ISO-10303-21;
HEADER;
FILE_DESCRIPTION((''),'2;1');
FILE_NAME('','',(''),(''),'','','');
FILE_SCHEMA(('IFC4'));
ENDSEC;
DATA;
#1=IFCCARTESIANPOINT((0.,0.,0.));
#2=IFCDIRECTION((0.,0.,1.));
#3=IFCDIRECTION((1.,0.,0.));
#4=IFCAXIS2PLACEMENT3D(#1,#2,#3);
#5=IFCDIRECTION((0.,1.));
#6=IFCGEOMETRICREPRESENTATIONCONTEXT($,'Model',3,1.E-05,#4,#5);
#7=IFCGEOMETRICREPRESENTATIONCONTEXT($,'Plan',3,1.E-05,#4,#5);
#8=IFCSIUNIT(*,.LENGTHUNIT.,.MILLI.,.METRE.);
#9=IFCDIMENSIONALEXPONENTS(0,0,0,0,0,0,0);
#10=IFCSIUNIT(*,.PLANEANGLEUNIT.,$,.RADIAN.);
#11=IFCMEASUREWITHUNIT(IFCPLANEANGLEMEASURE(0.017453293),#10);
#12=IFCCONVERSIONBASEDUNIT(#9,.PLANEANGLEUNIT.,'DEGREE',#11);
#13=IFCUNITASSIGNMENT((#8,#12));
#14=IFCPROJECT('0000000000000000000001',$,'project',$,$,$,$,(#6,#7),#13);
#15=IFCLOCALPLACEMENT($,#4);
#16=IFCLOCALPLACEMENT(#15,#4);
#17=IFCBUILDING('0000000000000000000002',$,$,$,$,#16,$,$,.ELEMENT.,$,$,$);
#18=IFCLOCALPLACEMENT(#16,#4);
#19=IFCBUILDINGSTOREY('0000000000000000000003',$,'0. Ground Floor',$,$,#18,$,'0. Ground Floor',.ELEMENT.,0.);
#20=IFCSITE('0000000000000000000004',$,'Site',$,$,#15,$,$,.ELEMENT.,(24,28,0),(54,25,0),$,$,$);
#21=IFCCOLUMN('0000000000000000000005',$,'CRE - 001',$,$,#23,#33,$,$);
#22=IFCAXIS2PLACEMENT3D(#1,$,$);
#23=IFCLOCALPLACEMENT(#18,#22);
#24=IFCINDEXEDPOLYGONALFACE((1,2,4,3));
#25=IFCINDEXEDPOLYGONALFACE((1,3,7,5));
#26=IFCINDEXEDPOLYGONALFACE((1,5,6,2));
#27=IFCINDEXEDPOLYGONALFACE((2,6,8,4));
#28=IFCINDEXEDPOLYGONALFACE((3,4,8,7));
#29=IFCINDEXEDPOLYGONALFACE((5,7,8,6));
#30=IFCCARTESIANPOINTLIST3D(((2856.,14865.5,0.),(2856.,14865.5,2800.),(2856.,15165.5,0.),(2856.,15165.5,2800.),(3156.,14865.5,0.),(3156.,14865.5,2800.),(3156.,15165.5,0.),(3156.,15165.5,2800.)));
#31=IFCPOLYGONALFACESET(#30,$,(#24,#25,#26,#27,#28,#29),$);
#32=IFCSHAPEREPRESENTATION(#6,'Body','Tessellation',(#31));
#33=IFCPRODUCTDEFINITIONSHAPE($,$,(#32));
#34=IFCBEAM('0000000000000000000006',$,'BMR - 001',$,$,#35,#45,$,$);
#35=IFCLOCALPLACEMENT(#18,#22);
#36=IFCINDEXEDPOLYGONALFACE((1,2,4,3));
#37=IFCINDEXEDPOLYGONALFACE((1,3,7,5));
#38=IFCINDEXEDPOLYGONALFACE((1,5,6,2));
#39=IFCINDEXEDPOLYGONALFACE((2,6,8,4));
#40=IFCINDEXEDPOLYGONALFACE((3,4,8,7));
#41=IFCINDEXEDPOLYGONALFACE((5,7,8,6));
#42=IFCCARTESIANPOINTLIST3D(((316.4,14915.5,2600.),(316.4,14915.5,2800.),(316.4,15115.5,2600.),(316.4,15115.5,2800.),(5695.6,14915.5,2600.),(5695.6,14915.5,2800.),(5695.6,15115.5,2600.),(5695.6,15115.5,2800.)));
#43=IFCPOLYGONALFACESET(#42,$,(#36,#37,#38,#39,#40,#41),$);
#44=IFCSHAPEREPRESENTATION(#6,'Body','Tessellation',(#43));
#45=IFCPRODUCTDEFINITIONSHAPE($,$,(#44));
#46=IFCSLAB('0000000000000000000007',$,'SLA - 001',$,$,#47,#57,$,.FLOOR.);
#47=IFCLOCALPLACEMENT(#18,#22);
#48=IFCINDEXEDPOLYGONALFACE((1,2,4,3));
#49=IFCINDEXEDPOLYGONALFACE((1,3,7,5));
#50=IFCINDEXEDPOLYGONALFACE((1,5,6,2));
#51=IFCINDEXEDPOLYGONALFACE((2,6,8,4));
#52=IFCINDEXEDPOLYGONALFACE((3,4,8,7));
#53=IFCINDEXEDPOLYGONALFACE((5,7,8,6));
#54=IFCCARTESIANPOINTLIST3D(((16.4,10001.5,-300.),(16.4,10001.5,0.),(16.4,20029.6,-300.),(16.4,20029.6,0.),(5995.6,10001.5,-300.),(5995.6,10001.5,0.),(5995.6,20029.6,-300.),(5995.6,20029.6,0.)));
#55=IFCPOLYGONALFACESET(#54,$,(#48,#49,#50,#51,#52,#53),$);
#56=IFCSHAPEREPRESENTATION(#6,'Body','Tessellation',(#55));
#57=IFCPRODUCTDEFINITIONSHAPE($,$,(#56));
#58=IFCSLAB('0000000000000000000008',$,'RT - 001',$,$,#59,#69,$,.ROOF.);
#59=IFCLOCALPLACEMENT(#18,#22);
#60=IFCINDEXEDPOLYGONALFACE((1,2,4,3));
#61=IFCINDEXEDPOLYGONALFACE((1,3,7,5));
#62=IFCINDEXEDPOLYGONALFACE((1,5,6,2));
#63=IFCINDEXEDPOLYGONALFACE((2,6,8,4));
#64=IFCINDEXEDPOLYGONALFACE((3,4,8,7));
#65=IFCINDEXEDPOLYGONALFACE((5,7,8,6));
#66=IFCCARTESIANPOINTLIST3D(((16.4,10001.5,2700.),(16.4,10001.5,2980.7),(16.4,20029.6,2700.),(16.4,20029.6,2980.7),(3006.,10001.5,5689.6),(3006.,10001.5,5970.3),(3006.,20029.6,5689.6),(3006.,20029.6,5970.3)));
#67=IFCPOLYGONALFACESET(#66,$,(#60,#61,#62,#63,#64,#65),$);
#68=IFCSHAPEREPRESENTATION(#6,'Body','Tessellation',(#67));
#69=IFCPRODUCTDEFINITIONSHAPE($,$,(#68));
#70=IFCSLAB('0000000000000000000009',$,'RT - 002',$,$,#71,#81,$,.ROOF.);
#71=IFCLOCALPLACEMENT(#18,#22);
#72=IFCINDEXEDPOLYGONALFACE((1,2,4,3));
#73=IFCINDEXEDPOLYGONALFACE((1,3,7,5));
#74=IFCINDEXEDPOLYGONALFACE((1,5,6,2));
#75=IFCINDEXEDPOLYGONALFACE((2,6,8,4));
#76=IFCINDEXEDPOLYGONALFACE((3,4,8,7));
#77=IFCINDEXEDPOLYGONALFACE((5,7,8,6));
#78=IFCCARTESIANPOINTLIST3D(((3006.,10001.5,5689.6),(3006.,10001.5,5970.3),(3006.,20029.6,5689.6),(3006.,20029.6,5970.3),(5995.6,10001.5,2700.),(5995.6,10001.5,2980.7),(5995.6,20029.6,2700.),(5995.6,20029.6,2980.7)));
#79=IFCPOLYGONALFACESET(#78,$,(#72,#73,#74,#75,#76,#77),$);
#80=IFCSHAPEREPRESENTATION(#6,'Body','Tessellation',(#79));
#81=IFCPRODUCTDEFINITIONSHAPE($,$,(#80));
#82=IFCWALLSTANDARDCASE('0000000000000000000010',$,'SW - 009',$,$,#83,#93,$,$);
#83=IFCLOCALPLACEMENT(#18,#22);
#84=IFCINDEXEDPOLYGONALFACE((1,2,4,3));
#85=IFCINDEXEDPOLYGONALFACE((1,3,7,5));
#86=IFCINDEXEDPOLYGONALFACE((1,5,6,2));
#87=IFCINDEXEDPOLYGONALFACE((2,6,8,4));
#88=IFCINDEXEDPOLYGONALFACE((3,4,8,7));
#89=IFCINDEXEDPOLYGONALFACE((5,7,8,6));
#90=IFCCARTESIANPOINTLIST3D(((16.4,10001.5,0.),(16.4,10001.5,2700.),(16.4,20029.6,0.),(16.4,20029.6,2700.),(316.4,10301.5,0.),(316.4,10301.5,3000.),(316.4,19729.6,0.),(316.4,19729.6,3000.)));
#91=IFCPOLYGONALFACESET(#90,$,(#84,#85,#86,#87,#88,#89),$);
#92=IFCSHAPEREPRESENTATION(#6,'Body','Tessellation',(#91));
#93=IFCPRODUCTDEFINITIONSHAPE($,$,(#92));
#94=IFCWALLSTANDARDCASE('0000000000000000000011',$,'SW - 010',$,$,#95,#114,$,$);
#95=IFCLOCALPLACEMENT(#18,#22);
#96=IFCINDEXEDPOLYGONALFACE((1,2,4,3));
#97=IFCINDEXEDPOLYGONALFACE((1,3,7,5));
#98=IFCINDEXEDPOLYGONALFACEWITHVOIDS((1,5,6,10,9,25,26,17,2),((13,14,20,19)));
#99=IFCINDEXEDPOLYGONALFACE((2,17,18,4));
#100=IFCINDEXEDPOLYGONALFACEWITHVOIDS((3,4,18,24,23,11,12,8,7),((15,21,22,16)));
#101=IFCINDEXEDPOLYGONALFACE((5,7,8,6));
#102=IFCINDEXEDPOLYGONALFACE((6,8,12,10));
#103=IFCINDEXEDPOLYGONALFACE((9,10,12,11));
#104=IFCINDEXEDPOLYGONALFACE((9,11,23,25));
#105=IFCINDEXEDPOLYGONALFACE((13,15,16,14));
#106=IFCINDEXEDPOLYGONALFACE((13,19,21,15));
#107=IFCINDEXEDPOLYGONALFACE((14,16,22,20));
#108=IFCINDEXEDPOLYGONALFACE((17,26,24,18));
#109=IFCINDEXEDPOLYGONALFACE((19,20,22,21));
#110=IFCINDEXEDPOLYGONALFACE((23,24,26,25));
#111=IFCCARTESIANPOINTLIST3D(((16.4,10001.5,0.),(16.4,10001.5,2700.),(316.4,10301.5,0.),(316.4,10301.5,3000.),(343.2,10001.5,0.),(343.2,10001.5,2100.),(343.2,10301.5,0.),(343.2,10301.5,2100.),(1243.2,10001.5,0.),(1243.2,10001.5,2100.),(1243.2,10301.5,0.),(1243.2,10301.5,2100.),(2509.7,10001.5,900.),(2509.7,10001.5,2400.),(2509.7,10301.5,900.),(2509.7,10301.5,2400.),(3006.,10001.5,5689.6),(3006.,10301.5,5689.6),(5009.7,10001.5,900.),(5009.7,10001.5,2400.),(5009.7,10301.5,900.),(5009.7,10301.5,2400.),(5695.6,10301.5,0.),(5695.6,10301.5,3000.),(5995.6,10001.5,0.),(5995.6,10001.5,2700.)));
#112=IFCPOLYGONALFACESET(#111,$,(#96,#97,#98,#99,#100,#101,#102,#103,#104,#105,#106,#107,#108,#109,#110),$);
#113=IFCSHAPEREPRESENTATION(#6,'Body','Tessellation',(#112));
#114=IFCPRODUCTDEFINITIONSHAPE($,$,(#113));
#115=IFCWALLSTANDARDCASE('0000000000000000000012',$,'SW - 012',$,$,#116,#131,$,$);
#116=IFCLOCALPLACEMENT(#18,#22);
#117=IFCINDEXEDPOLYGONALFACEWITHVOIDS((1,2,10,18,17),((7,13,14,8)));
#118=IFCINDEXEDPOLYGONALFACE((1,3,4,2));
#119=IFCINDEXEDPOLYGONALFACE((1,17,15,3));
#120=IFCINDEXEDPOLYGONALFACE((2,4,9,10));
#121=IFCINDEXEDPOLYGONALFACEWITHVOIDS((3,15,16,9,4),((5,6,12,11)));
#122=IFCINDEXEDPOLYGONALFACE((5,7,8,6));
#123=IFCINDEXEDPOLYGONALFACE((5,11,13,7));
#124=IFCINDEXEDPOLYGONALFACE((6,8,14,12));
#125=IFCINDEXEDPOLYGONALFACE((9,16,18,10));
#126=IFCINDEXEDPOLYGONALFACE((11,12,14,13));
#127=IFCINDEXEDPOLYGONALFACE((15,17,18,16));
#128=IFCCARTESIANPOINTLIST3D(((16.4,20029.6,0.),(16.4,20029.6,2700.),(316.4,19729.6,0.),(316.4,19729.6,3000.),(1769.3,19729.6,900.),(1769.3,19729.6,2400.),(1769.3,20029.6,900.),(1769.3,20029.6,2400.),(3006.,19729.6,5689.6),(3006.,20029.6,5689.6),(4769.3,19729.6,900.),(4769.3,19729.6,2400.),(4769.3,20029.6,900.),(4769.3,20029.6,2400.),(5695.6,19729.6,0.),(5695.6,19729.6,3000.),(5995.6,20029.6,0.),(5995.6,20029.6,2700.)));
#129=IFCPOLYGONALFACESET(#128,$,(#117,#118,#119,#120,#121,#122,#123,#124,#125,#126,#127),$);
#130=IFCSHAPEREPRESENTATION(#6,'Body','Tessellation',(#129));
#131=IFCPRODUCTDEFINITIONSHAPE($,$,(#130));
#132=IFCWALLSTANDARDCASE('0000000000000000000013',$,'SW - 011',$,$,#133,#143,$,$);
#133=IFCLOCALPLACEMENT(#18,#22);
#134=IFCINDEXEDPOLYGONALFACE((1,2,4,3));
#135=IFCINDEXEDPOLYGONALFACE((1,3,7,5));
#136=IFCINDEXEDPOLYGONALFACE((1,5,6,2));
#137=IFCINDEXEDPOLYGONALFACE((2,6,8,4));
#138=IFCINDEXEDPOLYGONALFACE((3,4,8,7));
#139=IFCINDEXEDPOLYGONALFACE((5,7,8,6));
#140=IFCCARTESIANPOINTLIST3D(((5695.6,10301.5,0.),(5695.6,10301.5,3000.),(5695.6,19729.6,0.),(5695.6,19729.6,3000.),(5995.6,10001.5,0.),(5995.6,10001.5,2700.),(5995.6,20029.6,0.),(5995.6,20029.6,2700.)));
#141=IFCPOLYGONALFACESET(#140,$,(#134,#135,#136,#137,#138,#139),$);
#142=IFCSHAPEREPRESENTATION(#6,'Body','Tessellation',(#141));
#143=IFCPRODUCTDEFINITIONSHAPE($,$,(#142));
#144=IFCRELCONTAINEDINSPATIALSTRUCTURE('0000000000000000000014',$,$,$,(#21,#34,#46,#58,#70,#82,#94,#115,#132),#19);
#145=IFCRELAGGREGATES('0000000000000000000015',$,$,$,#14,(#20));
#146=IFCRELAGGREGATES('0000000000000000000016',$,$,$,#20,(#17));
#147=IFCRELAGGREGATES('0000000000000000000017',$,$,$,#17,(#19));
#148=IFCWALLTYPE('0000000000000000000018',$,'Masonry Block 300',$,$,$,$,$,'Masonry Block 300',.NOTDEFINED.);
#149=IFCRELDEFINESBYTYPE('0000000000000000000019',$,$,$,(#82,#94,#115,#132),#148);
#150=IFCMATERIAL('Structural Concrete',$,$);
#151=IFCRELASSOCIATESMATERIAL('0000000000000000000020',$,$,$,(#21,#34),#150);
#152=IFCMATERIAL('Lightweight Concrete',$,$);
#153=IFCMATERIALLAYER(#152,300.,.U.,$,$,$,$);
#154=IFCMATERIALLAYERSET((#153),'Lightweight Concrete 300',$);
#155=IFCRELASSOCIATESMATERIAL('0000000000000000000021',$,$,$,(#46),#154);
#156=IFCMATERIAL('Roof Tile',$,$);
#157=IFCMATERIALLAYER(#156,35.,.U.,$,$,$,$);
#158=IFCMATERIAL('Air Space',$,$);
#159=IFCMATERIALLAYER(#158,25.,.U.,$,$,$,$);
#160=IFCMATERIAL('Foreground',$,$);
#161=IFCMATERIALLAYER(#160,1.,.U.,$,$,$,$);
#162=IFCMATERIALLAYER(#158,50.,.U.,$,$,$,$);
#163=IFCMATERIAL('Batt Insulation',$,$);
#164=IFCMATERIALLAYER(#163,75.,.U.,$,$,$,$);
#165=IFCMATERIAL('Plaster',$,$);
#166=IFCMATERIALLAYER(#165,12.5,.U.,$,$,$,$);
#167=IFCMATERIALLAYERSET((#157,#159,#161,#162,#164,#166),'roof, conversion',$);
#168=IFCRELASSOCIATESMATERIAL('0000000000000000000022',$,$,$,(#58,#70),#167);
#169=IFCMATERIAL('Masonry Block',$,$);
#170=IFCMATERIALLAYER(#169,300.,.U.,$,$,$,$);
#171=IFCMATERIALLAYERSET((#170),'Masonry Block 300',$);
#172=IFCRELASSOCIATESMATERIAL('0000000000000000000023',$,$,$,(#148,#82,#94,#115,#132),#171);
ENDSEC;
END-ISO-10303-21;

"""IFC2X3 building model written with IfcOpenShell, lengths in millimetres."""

from ifc_helpers import new_model, entity, si_unit, converted_unit, direction, frame, frame_2d, origin_with_axes, origin_2d_with_axis, place, context, project, spatial, polyline, rectangle, outline, extrude, clip, halfspace, bounded_halfspace, material, layer, layer_set, layer_usage, type_object, element, save


model = new_model("IFC2X3")

# Units and contexts
model_context = context("Model", 3, precision=1e-05, world=origin_with_axes(), true_north=direction((0.0, 1.0)))
plan_context = context("Plan", 3, precision=1e-05, world=origin_with_axes(), true_north=direction((0.0, 1.0)))
ifc_project = project(units=[si_unit("LENGTHUNIT", "METRE", prefix="MILLI"), converted_unit("PLANEANGLEUNIT", "DEGREE", entity("IfcPlaneAngleMeasure", 0.017453293), si_unit("PLANEANGLEUNIT", "RADIAN"), dimensions=[0, 0, 0, 0, 0, 0, 0])], contexts=[model_context, plan_context])

# Site, building, storey
site_placement = place(None, origin_with_axes())
site = spatial("IfcSite", under=ifc_project, at=site_placement, Name="Site", CompositionType="ELEMENT", RefLatitude=(24, 28, 0), RefLongitude=(54, 25, 0))
building_placement = place(site_placement, origin_with_axes())
building = spatial("IfcBuilding", under=site, at=building_placement, CompositionType="ELEMENT")
storey_placement = place(building_placement, origin_with_axes())
storey = spatial("IfcBuildingStorey", under=building, at=storey_placement, Name="0. Ground Floor", LongName="0. Ground Floor", CompositionType="ELEMENT", Elevation=0.0)

# Column
ifc_material_1 = material(Name="Structural Concrete")
column_placement = place(storey_placement, frame((3006.0, 15015.5, 0.0), z_axis=(0.0, 0.0, 1.0), x_axis=(1.0, 0.0, 0.0)))
element("IfcColumn", 1, at=column_placement, inside=storey, material=ifc_material_1, Name="CRE - 001", context=model_context, shape_type="SweptSolid", body=[
    extrude(rectangle(XDim=300.0, YDim=300.0, at=origin_2d_with_axis()), origin_with_axes(), (0.0, 0.0, 1.0), 2800.0),
])

# Beam
beam_placement = place(storey_placement, frame((316.4, 15015.5, 2800.0), z_axis=(0.0, 0.0, 1.0), x_axis=(0.0, -1.0, 0.0)))
element("IfcBeam", 2, at=beam_placement, inside=storey, material=ifc_material_1, Name="BMR - 001", context=model_context, shape_type="SweptSolid", body=[
    extrude(rectangle(XDim=200.0, YDim=200.0, at=frame_2d((-100.0, 0.0), x_axis=(1.0, 0.0))), frame((0.0, 0.0, 0.0), z_axis=(0.0, 1.0, 0.0), x_axis=(0.0, 0.0, 1.0)), (0.0, 0.0, 1.0), 5379.1),
])

# Slabs
ifc_material_2 = material(Name="Lightweight Concrete")
ifc_layer_1 = layer(ifc_material_2, 300.0, ventilated="UNKNOWN")
ifc_layer_set_1 = layer_set([ifc_layer_1], Name="Lightweight Concrete 300")
ifc_layer_usage_1 = layer_usage(ifc_layer_set_1, "AXIS3", "NEGATIVE", 300.0)
slab_1_placement = place(storey_placement, frame((16.4, 20029.6, -300.0), z_axis=(0.0, 0.0, 1.0), x_axis=(1.0, 0.0, 0.0)))
element("IfcSlab", 3, at=slab_1_placement, inside=storey, material=ifc_layer_usage_1, Name="SLA - 001", PredefinedType="FLOOR", context=model_context, shape_type="SweptSolid", body=[
    extrude(outline(polyline([(0.0, 0.0), (5979.1, 0.0), (5979.1, -10028.0), (0.0, -10028.0), (0.0, 0.0)])), origin_with_axes(), (0.0, 0.0, 1.0), 300.0),
])
ifc_material_3 = material(Name="Roof Tile")
ifc_layer_2 = layer(ifc_material_3, 35.0, ventilated="UNKNOWN")
ifc_material_4 = material(Name="Air Space")
ifc_layer_3 = layer(ifc_material_4, 25.0, ventilated="UNKNOWN")
ifc_material_5 = material(Name="Foreground")
ifc_layer_4 = layer(ifc_material_5, 1.0, ventilated="UNKNOWN")
ifc_layer_5 = layer(ifc_material_4, 50.0, ventilated="UNKNOWN")
ifc_material_6 = material(Name="Batt Insulation")
ifc_layer_6 = layer(ifc_material_6, 75.0, ventilated="UNKNOWN")
ifc_material_7 = material(Name="Plaster")
ifc_layer_7 = layer(ifc_material_7, 12.5, ventilated="UNKNOWN")
ifc_layer_set_2 = layer_set([ifc_layer_2, ifc_layer_3, ifc_layer_4, ifc_layer_5, ifc_layer_6, ifc_layer_7], Name="roof, conversion")
ifc_layer_usage_2 = layer_usage(ifc_layer_set_2, "AXIS3", "NEGATIVE", 198.5)
slab_2_placement = place(storey_placement, frame((16.4, 20029.6, 2700.0), z_axis=(-0.707107, 0.0, 0.707107), x_axis=(0.0, -1.0, 0.0)))
element("IfcSlab", 4, at=slab_2_placement, inside=storey, material=ifc_layer_usage_2, Name="RT - 001", PredefinedType="ROOF", context=model_context, shape_type="SweptSolid", body=[
    extrude(outline(polyline([(0.0, 0.0), (0.0, 4227.9), (10028.0, 4227.9), (10028.0, 0.0), (0.0, 0.0)])), origin_with_axes(), (0.0, 0.707107, 0.707107), 280.7),
])
ifc_layer_usage_3 = layer_usage(ifc_layer_set_2, "AXIS3", "NEGATIVE", 198.5)
slab_3_placement = place(storey_placement, frame((5995.6, 10001.5, 2700.0), z_axis=(0.707107, 0.0, 0.707107), x_axis=(0.0, 1.0, 0.0)))
element("IfcSlab", 5, at=slab_3_placement, inside=storey, material=ifc_layer_usage_3, Name="RT - 002", PredefinedType="ROOF", context=model_context, shape_type="SweptSolid", body=[
    extrude(outline(polyline([(0.0, 0.0), (10028.0, 0.0), (10028.0, 4227.9), (0.0, 4227.9), (0.0, 0.0)])), origin_with_axes(), (0.0, 0.707107, 0.707107), 280.7),
])

# Wall
ifc_material_8 = material(Name="Masonry Block")
ifc_layer_8 = layer(ifc_material_8, 300.0, ventilated="UNKNOWN")
ifc_layer_set_3 = layer_set([ifc_layer_8], Name="Masonry Block 300")
ifc_layer_usage_4 = layer_usage(ifc_layer_set_3, "AXIS2", "POSITIVE", 0.0)
wall_type_1 = type_object("IfcWallType", Name="Masonry Block 300", ElementType="Masonry Block 300", PredefinedType="NOTDEFINED", material=ifc_layer_set_3)
wall_1_placement = place(storey_placement, frame((16.4, 20029.6, 0.0), z_axis=(0.0, 0.0, 1.0), x_axis=(0.0, -1.0, 0.0)))
element("IfcWallStandardCase", 6, at=wall_1_placement, inside=storey, type_object=wall_type_1, material=ifc_layer_usage_4, Name="SW - 009", context=model_context, shape_type="Clipping", body=[
    clip(extrude(outline(polyline([(0.0, 0.0), (10028.0, 0.0), (9728.0, 300.0), (300.0, 300.0), (0.0, 0.0)])), origin_with_axes(), (0.0, 0.0, 1.0), 6000.0), halfspace(frame((0.0, -1350.0, 1350.0), z_axis=(0.0, 0.707107, -0.707107), x_axis=(0.0, 0.707107, 0.707107)), True)),
])

# Wall, openings
ifc_layer_usage_5 = layer_usage(ifc_layer_set_3, "AXIS2", "POSITIVE", 0.0)
wall_2_placement = place(storey_placement, frame((16.4, 10001.5, 0.0), z_axis=(0.0, 0.0, 1.0), x_axis=(1.0, 0.0, 0.0)))
wall_2 = element("IfcWallStandardCase", 7, at=wall_2_placement, inside=storey, type_object=wall_type_1, material=ifc_layer_usage_5, Name="SW - 010", context=model_context, shape_type="Clipping", body=[
    clip(clip(extrude(outline(polyline([(0.0, 0.0), (5979.1, 0.0), (5679.1, 300.0), (300.0, 300.0), (0.0, 0.0)])), origin_with_axes(), (0.0, 0.0, 1.0), 6000.0), bounded_halfspace(frame((-1350.0, 0.0, 1350.0), z_axis=(0.707107, 0.0, -0.707107), x_axis=(0.0, 1.0, 0.0)), True, origin_with_axes(), polyline([(2989.6, -150.0), (2989.6, 450.0), (-10.0, 450.0), (-10.0, -150.0), (2989.6, -150.0)]))), bounded_halfspace(frame((4339.6, 0.0, 4339.6), z_axis=(-0.707107, 0.0, -0.707107), x_axis=(0.0, 1.0, 0.0)), True, origin_with_axes(), polyline([(2989.6, -150.0), (2989.6, 450.0), (5989.1, 450.0), (5989.1, -150.0), (2989.6, -150.0)]))),
])
opening_1_placement = place(wall_2_placement, frame((3743.3, 0.0, 900.0), z_axis=(0.0, 0.0, 1.0), x_axis=(1.0, 0.0, 0.0)))
element("IfcOpeningElement", 8, at=opening_1_placement, cuts=wall_2, ObjectType="Opening", context=model_context, shape_type="SweptSolid", body=[
    extrude(rectangle(XDim=2500.0, YDim=1500.0, at=frame_2d((0.0, 750.0), x_axis=(-1.0, 0.0))), frame((0.0, 0.0, 0.0), z_axis=(0.0, 1.0, 0.0), x_axis=(-1.0, 0.0, 0.0)), (0.0, 0.0, 1.0), 300.0),
])
opening_2_placement = place(wall_2_placement, frame((776.8, 0.0, 0.0), z_axis=(0.0, 0.0, 1.0), x_axis=(1.0, 0.0, 0.0)))
element("IfcOpeningElement", 9, at=opening_2_placement, cuts=wall_2, ObjectType="Opening", context=model_context, shape_type="SweptSolid", body=[
    extrude(rectangle(XDim=900.0, YDim=2100.0, at=frame_2d((0.0, 1050.0), x_axis=(-1.0, 0.0))), frame((0.0, 0.0, 0.0), z_axis=(0.0, 1.0, 0.0), x_axis=(-1.0, 0.0, 0.0)), (0.0, 0.0, 1.0), 300.0),
])

# Wall, opening
ifc_layer_usage_6 = layer_usage(ifc_layer_set_3, "AXIS2", "POSITIVE", 0.0)
wall_3_placement = place(storey_placement, frame((5995.6, 20029.6, 0.0), z_axis=(0.0, 0.0, 1.0), x_axis=(-1.0, 0.0, 0.0)))
wall_3 = element("IfcWallStandardCase", 10, at=wall_3_placement, inside=storey, type_object=wall_type_1, material=ifc_layer_usage_6, Name="SW - 012", context=model_context, shape_type="Clipping", body=[
    clip(clip(extrude(outline(polyline([(0.0, 0.0), (5979.1, 0.0), (5679.1, 300.0), (300.0, 300.0), (0.0, 0.0)])), origin_with_axes(), (0.0, 0.0, 1.0), 6000.0), bounded_halfspace(frame((4339.6, 0.0, 4339.6), z_axis=(-0.707107, 0.0, -0.707107), x_axis=(0.0, 1.0, 0.0)), True, origin_with_axes(), polyline([(2989.6, -150.0), (2989.6, 450.0), (5989.1, 450.0), (5989.1, -150.0), (2989.6, -150.0)]))), bounded_halfspace(frame((-1350.0, 0.0, 1350.0), z_axis=(0.707107, 0.0, -0.707107), x_axis=(0.0, 1.0, 0.0)), True, origin_with_axes(), polyline([(2989.6, -150.0), (2989.6, 450.0), (-10.0, 450.0), (-10.0, -150.0), (2989.6, -150.0)]))),
])
opening_3_placement = place(wall_3_placement, frame((2726.3, 0.0, 900.0), z_axis=(0.0, 0.0, 1.0), x_axis=(1.0, 0.0, 0.0)))
element("IfcOpeningElement", 11, at=opening_3_placement, cuts=wall_3, ObjectType="Opening", context=model_context, shape_type="SweptSolid", body=[
    extrude(rectangle(XDim=3000.0, YDim=1500.0, at=frame_2d((0.0, 750.0), x_axis=(1.0, 0.0))), frame((0.0, 0.0, 0.0), z_axis=(0.0, 1.0, 0.0), x_axis=(-1.0, 0.0, 0.0)), (0.0, 0.0, 1.0), 300.0),
])

# Wall
ifc_layer_usage_7 = layer_usage(ifc_layer_set_3, "AXIS2", "POSITIVE", 0.0)
wall_4_placement = place(storey_placement, frame((5995.6, 10001.5, 0.0), z_axis=(0.0, 0.0, 1.0), x_axis=(0.0, 1.0, 0.0)))
element("IfcWallStandardCase", 12, at=wall_4_placement, inside=storey, type_object=wall_type_1, material=ifc_layer_usage_7, Name="SW - 011", context=model_context, shape_type="Clipping", body=[
    clip(extrude(outline(polyline([(0.0, 0.0), (10028.0, 0.0), (9728.0, 300.0), (300.0, 300.0), (0.0, 0.0)])), origin_with_axes(), (0.0, 0.0, 1.0), 6000.0), halfspace(frame((0.0, -1350.0, 1350.0), z_axis=(0.0, 0.707107, -0.707107), x_axis=(0.0, 0.707107, 0.707107)), True)),
])

save(model, "model.ifc")
